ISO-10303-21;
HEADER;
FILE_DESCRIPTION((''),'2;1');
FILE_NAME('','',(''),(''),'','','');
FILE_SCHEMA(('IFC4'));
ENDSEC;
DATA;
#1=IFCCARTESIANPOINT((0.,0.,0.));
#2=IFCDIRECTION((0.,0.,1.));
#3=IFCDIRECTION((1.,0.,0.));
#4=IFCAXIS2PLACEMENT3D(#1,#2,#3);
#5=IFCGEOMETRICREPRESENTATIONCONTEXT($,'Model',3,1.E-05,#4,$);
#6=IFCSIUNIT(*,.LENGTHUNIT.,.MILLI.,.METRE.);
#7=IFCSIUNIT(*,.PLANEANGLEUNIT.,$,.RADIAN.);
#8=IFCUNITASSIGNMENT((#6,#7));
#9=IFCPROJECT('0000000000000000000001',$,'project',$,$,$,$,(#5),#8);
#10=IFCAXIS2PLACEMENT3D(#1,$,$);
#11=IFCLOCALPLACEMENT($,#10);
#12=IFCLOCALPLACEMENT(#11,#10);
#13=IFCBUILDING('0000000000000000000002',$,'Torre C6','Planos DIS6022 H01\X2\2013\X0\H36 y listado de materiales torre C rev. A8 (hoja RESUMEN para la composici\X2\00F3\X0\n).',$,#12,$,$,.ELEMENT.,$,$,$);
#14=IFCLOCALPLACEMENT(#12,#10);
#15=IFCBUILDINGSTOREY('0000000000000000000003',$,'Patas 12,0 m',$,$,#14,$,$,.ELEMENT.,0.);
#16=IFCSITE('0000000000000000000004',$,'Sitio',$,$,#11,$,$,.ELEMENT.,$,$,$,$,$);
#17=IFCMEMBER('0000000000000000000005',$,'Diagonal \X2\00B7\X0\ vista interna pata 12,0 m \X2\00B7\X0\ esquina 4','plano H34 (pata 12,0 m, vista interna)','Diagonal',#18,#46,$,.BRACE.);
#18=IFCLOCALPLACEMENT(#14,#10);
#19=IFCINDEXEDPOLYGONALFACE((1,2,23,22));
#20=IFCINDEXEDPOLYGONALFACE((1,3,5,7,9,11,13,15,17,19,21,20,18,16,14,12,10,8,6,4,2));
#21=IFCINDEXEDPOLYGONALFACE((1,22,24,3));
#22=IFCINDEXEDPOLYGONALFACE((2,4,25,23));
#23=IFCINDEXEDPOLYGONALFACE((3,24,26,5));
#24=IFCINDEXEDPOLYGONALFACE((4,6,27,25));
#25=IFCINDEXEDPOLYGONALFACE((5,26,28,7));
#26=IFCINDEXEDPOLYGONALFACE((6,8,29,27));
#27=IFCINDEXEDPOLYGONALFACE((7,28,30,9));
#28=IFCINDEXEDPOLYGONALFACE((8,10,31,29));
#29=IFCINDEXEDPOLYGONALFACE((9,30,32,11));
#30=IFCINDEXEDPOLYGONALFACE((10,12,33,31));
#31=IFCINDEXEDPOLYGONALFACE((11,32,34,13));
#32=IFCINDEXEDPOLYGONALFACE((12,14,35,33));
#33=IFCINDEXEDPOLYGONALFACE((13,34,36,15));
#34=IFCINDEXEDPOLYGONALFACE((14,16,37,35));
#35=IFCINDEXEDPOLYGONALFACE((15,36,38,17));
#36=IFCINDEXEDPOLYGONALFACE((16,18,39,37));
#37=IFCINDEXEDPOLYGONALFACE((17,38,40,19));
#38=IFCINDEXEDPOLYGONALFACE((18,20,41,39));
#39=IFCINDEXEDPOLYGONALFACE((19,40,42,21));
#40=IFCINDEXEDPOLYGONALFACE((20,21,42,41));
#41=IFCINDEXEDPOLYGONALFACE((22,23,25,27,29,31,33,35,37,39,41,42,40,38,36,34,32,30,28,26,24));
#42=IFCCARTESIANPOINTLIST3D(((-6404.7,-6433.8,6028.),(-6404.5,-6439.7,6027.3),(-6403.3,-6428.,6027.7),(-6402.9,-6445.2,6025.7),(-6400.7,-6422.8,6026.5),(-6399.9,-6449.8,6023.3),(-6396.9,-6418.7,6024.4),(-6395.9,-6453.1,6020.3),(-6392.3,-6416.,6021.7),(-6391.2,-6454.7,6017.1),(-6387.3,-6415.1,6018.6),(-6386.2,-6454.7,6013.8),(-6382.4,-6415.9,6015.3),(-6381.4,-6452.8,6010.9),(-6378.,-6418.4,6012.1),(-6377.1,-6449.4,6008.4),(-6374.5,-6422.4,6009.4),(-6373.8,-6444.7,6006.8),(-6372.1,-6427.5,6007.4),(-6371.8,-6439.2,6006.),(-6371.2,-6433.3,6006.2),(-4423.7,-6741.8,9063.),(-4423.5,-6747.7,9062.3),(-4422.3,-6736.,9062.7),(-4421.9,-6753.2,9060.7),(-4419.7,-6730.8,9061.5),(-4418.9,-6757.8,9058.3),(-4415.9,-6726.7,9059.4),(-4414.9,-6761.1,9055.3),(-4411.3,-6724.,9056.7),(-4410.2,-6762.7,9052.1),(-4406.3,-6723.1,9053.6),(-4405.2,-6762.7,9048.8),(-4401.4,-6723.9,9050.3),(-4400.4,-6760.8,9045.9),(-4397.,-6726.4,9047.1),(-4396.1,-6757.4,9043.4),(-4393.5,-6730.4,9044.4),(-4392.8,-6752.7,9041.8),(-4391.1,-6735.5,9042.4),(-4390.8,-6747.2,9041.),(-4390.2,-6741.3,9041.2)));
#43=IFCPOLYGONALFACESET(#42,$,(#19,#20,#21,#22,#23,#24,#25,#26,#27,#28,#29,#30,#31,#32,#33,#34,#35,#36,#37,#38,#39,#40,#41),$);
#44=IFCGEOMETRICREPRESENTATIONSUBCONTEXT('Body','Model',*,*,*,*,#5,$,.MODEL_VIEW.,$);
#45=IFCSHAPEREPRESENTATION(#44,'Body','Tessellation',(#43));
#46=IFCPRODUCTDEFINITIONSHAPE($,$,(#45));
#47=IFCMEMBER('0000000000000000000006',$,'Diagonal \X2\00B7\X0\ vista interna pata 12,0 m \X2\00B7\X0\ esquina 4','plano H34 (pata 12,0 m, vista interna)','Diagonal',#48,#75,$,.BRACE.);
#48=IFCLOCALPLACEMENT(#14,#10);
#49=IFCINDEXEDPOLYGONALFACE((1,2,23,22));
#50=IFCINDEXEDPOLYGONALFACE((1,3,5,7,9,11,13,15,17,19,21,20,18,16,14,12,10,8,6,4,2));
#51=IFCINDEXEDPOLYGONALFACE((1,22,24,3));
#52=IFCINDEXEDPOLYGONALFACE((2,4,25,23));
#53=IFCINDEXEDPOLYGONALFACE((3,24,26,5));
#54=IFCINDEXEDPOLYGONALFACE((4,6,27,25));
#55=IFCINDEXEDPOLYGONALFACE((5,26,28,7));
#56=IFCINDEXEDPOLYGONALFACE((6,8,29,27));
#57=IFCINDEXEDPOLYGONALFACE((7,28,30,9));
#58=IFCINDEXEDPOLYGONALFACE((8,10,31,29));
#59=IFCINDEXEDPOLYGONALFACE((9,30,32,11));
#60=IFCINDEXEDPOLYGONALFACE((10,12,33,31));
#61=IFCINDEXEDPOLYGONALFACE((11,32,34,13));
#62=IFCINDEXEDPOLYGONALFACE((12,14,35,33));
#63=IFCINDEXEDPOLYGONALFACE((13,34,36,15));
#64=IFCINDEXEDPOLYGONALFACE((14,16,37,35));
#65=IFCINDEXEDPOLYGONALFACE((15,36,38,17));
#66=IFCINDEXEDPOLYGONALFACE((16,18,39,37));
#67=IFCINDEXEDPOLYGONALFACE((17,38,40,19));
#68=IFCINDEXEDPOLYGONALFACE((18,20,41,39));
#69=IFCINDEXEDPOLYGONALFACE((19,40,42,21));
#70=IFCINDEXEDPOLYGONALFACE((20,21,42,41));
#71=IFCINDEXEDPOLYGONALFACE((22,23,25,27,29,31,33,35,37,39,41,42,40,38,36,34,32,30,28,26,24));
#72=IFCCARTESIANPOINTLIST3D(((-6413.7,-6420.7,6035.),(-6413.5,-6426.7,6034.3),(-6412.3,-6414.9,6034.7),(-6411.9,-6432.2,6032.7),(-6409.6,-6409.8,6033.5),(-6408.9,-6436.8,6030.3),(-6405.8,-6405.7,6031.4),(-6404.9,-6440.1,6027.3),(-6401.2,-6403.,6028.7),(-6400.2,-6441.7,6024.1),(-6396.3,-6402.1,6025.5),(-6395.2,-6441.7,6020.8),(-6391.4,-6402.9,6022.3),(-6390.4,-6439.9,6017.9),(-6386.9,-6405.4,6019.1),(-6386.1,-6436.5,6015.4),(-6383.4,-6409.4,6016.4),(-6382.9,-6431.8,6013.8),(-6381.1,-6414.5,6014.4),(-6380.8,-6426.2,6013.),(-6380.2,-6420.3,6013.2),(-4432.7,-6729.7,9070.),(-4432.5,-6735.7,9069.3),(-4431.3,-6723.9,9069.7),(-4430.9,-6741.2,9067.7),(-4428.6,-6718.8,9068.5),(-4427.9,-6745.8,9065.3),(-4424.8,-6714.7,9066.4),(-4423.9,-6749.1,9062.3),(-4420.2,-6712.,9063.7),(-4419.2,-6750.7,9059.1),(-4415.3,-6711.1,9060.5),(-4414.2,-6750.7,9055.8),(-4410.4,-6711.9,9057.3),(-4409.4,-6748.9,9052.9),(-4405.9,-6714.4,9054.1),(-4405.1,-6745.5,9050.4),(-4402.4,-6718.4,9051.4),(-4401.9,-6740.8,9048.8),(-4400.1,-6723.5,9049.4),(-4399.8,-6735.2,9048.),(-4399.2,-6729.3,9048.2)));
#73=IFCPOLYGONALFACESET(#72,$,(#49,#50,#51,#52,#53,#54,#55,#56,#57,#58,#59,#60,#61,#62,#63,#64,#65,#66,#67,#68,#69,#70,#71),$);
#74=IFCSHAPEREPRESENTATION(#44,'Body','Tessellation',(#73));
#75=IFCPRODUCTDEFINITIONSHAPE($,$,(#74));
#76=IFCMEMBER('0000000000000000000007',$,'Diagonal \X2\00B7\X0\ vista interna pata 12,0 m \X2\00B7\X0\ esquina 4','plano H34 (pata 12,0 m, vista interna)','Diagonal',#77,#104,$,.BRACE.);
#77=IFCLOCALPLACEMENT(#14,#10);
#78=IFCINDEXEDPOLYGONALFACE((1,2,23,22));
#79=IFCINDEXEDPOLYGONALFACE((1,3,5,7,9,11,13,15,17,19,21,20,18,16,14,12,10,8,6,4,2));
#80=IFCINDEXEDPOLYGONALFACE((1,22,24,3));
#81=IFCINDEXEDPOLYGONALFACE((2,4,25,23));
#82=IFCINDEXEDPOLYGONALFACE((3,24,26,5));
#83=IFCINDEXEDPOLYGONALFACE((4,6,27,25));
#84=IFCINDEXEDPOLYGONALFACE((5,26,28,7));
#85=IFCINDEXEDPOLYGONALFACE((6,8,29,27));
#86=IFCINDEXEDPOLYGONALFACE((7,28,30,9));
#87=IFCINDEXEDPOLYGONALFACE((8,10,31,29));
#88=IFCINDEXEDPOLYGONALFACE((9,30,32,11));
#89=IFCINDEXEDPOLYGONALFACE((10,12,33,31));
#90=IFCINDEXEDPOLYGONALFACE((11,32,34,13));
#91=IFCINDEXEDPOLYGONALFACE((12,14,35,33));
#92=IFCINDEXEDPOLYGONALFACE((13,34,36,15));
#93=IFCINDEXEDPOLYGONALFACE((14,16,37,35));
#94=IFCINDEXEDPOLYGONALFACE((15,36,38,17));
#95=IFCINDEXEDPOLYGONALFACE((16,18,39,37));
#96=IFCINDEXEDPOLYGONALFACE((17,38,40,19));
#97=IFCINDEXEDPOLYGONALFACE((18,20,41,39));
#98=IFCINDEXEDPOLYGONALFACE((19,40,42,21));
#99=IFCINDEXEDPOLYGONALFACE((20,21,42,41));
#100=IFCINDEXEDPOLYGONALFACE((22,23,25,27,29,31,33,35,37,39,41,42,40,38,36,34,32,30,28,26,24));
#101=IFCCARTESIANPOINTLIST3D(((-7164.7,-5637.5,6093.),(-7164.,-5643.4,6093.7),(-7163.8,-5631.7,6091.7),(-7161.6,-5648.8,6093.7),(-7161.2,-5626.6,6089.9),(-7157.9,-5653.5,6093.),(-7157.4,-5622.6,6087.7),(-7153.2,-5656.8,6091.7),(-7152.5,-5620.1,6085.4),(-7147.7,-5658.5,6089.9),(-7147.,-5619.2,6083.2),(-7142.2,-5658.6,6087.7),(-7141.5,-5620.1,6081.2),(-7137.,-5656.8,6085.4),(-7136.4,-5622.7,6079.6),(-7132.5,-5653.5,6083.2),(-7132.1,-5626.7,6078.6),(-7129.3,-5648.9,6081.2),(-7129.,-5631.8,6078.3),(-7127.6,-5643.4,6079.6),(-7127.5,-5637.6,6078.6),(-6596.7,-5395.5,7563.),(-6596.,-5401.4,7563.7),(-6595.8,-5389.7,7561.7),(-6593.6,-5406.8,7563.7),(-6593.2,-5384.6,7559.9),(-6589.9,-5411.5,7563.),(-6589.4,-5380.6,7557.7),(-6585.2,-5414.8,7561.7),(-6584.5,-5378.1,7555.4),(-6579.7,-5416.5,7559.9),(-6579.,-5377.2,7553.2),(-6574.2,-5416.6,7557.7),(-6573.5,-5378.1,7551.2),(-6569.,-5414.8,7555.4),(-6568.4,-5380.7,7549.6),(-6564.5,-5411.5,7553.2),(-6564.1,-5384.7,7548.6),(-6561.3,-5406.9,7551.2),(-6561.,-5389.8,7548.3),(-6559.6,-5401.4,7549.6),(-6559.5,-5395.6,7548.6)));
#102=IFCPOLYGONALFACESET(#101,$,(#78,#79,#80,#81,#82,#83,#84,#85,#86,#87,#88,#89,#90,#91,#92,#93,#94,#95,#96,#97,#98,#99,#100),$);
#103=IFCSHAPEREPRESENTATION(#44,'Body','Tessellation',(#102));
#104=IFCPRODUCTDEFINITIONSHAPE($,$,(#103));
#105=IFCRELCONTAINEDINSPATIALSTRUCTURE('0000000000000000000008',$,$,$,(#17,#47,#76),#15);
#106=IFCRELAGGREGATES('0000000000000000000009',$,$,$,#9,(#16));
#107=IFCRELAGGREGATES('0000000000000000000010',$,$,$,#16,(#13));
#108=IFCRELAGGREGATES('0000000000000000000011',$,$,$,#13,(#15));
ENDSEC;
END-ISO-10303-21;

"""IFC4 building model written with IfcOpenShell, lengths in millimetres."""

from ifc_helpers import new_model, si_unit, frame, origin, origin_with_axes, place, context, subcontext, project, spatial, circle, extrude, element, save


model = new_model("IFC4")

# Units and contexts
model_context = context("Model", 3, precision=1e-05, world=origin_with_axes())
body_context = subcontext(model_context, "Body", "Model", "MODEL_VIEW")
ifc_project = project(units=[si_unit("LENGTHUNIT", "METRE", prefix="MILLI"), si_unit("PLANEANGLEUNIT", "RADIAN")], contexts=[model_context])

# Site, building, storey
site_placement = place(None, origin())
site = spatial("IfcSite", under=ifc_project, at=site_placement, Name="Sitio", CompositionType="ELEMENT")
building_placement = place(site_placement, origin())
building = spatial("IfcBuilding", under=site, at=building_placement, Name="Torre C6", Description="Planos DIS6022 H01–H36 y listado de materiales torre C rev. A8 (hoja RESUMEN para la composición).", CompositionType="ELEMENT")
storey_placement = place(building_placement, origin())
storey = spatial("IfcBuildingStorey", under=building, at=storey_placement, Name="Patas 12,0 m", CompositionType="ELEMENT", Elevation=0.0)

# Members
member_1_placement = place(storey_placement, frame((-6388.0, -6435.0, 6017.0), z_axis=(0.544624, -0.084677, 0.834394), x_axis=(0.501407, 0.830384, -0.243008)))
element("IfcMember", 1, at=member_1_placement, inside=storey, Name="Diagonal · vista interna pata 12,0 m · esquina 4", Description="plano H34 (pata 12,0 m, vista interna)", ObjectType="Diagonal", PredefinedType="BRACE", context=body_context, shape_type="SweptSolid", body=[
    extrude(circle(Radius=20.0), None, (0.0, 0.0, 1.0), 3637.4),
])
member_2_placement = place(storey_placement, frame((-6397.0, -6422.0, 6024.0), z_axis=(0.544612, -0.08495, 0.834375), x_axis=(0.502565, 0.829517, -0.243578)))
element("IfcMember", 2, at=member_2_placement, inside=storey, Name="Diagonal · vista interna pata 12,0 m · esquina 4", Description="plano H34 (pata 12,0 m, vista interna)", ObjectType="Diagonal", PredefinedType="BRACE", context=body_context, shape_type="SweptSolid", body=[
    extrude(circle(Radius=20.0), None, (0.0, 0.0, 1.0), 3637.5),
])
member_3_placement = place(storey_placement, frame((-7146.0, -5639.0, 6086.0), z_axis=(0.356249, 0.151782, 0.921981), x_axis=(0.696713, 0.614357, -0.370345)))
element("IfcMember", 3, at=member_3_placement, inside=storey, Name="Diagonal · vista interna pata 12,0 m · esquina 4", Description="plano H34 (pata 12,0 m, vista interna)", ObjectType="Diagonal", PredefinedType="BRACE", context=body_context, shape_type="SweptSolid", body=[
    extrude(circle(Radius=20.0), None, (0.0, 0.0, 1.0), 1594.4),
])

save(model, "model.ifc")
